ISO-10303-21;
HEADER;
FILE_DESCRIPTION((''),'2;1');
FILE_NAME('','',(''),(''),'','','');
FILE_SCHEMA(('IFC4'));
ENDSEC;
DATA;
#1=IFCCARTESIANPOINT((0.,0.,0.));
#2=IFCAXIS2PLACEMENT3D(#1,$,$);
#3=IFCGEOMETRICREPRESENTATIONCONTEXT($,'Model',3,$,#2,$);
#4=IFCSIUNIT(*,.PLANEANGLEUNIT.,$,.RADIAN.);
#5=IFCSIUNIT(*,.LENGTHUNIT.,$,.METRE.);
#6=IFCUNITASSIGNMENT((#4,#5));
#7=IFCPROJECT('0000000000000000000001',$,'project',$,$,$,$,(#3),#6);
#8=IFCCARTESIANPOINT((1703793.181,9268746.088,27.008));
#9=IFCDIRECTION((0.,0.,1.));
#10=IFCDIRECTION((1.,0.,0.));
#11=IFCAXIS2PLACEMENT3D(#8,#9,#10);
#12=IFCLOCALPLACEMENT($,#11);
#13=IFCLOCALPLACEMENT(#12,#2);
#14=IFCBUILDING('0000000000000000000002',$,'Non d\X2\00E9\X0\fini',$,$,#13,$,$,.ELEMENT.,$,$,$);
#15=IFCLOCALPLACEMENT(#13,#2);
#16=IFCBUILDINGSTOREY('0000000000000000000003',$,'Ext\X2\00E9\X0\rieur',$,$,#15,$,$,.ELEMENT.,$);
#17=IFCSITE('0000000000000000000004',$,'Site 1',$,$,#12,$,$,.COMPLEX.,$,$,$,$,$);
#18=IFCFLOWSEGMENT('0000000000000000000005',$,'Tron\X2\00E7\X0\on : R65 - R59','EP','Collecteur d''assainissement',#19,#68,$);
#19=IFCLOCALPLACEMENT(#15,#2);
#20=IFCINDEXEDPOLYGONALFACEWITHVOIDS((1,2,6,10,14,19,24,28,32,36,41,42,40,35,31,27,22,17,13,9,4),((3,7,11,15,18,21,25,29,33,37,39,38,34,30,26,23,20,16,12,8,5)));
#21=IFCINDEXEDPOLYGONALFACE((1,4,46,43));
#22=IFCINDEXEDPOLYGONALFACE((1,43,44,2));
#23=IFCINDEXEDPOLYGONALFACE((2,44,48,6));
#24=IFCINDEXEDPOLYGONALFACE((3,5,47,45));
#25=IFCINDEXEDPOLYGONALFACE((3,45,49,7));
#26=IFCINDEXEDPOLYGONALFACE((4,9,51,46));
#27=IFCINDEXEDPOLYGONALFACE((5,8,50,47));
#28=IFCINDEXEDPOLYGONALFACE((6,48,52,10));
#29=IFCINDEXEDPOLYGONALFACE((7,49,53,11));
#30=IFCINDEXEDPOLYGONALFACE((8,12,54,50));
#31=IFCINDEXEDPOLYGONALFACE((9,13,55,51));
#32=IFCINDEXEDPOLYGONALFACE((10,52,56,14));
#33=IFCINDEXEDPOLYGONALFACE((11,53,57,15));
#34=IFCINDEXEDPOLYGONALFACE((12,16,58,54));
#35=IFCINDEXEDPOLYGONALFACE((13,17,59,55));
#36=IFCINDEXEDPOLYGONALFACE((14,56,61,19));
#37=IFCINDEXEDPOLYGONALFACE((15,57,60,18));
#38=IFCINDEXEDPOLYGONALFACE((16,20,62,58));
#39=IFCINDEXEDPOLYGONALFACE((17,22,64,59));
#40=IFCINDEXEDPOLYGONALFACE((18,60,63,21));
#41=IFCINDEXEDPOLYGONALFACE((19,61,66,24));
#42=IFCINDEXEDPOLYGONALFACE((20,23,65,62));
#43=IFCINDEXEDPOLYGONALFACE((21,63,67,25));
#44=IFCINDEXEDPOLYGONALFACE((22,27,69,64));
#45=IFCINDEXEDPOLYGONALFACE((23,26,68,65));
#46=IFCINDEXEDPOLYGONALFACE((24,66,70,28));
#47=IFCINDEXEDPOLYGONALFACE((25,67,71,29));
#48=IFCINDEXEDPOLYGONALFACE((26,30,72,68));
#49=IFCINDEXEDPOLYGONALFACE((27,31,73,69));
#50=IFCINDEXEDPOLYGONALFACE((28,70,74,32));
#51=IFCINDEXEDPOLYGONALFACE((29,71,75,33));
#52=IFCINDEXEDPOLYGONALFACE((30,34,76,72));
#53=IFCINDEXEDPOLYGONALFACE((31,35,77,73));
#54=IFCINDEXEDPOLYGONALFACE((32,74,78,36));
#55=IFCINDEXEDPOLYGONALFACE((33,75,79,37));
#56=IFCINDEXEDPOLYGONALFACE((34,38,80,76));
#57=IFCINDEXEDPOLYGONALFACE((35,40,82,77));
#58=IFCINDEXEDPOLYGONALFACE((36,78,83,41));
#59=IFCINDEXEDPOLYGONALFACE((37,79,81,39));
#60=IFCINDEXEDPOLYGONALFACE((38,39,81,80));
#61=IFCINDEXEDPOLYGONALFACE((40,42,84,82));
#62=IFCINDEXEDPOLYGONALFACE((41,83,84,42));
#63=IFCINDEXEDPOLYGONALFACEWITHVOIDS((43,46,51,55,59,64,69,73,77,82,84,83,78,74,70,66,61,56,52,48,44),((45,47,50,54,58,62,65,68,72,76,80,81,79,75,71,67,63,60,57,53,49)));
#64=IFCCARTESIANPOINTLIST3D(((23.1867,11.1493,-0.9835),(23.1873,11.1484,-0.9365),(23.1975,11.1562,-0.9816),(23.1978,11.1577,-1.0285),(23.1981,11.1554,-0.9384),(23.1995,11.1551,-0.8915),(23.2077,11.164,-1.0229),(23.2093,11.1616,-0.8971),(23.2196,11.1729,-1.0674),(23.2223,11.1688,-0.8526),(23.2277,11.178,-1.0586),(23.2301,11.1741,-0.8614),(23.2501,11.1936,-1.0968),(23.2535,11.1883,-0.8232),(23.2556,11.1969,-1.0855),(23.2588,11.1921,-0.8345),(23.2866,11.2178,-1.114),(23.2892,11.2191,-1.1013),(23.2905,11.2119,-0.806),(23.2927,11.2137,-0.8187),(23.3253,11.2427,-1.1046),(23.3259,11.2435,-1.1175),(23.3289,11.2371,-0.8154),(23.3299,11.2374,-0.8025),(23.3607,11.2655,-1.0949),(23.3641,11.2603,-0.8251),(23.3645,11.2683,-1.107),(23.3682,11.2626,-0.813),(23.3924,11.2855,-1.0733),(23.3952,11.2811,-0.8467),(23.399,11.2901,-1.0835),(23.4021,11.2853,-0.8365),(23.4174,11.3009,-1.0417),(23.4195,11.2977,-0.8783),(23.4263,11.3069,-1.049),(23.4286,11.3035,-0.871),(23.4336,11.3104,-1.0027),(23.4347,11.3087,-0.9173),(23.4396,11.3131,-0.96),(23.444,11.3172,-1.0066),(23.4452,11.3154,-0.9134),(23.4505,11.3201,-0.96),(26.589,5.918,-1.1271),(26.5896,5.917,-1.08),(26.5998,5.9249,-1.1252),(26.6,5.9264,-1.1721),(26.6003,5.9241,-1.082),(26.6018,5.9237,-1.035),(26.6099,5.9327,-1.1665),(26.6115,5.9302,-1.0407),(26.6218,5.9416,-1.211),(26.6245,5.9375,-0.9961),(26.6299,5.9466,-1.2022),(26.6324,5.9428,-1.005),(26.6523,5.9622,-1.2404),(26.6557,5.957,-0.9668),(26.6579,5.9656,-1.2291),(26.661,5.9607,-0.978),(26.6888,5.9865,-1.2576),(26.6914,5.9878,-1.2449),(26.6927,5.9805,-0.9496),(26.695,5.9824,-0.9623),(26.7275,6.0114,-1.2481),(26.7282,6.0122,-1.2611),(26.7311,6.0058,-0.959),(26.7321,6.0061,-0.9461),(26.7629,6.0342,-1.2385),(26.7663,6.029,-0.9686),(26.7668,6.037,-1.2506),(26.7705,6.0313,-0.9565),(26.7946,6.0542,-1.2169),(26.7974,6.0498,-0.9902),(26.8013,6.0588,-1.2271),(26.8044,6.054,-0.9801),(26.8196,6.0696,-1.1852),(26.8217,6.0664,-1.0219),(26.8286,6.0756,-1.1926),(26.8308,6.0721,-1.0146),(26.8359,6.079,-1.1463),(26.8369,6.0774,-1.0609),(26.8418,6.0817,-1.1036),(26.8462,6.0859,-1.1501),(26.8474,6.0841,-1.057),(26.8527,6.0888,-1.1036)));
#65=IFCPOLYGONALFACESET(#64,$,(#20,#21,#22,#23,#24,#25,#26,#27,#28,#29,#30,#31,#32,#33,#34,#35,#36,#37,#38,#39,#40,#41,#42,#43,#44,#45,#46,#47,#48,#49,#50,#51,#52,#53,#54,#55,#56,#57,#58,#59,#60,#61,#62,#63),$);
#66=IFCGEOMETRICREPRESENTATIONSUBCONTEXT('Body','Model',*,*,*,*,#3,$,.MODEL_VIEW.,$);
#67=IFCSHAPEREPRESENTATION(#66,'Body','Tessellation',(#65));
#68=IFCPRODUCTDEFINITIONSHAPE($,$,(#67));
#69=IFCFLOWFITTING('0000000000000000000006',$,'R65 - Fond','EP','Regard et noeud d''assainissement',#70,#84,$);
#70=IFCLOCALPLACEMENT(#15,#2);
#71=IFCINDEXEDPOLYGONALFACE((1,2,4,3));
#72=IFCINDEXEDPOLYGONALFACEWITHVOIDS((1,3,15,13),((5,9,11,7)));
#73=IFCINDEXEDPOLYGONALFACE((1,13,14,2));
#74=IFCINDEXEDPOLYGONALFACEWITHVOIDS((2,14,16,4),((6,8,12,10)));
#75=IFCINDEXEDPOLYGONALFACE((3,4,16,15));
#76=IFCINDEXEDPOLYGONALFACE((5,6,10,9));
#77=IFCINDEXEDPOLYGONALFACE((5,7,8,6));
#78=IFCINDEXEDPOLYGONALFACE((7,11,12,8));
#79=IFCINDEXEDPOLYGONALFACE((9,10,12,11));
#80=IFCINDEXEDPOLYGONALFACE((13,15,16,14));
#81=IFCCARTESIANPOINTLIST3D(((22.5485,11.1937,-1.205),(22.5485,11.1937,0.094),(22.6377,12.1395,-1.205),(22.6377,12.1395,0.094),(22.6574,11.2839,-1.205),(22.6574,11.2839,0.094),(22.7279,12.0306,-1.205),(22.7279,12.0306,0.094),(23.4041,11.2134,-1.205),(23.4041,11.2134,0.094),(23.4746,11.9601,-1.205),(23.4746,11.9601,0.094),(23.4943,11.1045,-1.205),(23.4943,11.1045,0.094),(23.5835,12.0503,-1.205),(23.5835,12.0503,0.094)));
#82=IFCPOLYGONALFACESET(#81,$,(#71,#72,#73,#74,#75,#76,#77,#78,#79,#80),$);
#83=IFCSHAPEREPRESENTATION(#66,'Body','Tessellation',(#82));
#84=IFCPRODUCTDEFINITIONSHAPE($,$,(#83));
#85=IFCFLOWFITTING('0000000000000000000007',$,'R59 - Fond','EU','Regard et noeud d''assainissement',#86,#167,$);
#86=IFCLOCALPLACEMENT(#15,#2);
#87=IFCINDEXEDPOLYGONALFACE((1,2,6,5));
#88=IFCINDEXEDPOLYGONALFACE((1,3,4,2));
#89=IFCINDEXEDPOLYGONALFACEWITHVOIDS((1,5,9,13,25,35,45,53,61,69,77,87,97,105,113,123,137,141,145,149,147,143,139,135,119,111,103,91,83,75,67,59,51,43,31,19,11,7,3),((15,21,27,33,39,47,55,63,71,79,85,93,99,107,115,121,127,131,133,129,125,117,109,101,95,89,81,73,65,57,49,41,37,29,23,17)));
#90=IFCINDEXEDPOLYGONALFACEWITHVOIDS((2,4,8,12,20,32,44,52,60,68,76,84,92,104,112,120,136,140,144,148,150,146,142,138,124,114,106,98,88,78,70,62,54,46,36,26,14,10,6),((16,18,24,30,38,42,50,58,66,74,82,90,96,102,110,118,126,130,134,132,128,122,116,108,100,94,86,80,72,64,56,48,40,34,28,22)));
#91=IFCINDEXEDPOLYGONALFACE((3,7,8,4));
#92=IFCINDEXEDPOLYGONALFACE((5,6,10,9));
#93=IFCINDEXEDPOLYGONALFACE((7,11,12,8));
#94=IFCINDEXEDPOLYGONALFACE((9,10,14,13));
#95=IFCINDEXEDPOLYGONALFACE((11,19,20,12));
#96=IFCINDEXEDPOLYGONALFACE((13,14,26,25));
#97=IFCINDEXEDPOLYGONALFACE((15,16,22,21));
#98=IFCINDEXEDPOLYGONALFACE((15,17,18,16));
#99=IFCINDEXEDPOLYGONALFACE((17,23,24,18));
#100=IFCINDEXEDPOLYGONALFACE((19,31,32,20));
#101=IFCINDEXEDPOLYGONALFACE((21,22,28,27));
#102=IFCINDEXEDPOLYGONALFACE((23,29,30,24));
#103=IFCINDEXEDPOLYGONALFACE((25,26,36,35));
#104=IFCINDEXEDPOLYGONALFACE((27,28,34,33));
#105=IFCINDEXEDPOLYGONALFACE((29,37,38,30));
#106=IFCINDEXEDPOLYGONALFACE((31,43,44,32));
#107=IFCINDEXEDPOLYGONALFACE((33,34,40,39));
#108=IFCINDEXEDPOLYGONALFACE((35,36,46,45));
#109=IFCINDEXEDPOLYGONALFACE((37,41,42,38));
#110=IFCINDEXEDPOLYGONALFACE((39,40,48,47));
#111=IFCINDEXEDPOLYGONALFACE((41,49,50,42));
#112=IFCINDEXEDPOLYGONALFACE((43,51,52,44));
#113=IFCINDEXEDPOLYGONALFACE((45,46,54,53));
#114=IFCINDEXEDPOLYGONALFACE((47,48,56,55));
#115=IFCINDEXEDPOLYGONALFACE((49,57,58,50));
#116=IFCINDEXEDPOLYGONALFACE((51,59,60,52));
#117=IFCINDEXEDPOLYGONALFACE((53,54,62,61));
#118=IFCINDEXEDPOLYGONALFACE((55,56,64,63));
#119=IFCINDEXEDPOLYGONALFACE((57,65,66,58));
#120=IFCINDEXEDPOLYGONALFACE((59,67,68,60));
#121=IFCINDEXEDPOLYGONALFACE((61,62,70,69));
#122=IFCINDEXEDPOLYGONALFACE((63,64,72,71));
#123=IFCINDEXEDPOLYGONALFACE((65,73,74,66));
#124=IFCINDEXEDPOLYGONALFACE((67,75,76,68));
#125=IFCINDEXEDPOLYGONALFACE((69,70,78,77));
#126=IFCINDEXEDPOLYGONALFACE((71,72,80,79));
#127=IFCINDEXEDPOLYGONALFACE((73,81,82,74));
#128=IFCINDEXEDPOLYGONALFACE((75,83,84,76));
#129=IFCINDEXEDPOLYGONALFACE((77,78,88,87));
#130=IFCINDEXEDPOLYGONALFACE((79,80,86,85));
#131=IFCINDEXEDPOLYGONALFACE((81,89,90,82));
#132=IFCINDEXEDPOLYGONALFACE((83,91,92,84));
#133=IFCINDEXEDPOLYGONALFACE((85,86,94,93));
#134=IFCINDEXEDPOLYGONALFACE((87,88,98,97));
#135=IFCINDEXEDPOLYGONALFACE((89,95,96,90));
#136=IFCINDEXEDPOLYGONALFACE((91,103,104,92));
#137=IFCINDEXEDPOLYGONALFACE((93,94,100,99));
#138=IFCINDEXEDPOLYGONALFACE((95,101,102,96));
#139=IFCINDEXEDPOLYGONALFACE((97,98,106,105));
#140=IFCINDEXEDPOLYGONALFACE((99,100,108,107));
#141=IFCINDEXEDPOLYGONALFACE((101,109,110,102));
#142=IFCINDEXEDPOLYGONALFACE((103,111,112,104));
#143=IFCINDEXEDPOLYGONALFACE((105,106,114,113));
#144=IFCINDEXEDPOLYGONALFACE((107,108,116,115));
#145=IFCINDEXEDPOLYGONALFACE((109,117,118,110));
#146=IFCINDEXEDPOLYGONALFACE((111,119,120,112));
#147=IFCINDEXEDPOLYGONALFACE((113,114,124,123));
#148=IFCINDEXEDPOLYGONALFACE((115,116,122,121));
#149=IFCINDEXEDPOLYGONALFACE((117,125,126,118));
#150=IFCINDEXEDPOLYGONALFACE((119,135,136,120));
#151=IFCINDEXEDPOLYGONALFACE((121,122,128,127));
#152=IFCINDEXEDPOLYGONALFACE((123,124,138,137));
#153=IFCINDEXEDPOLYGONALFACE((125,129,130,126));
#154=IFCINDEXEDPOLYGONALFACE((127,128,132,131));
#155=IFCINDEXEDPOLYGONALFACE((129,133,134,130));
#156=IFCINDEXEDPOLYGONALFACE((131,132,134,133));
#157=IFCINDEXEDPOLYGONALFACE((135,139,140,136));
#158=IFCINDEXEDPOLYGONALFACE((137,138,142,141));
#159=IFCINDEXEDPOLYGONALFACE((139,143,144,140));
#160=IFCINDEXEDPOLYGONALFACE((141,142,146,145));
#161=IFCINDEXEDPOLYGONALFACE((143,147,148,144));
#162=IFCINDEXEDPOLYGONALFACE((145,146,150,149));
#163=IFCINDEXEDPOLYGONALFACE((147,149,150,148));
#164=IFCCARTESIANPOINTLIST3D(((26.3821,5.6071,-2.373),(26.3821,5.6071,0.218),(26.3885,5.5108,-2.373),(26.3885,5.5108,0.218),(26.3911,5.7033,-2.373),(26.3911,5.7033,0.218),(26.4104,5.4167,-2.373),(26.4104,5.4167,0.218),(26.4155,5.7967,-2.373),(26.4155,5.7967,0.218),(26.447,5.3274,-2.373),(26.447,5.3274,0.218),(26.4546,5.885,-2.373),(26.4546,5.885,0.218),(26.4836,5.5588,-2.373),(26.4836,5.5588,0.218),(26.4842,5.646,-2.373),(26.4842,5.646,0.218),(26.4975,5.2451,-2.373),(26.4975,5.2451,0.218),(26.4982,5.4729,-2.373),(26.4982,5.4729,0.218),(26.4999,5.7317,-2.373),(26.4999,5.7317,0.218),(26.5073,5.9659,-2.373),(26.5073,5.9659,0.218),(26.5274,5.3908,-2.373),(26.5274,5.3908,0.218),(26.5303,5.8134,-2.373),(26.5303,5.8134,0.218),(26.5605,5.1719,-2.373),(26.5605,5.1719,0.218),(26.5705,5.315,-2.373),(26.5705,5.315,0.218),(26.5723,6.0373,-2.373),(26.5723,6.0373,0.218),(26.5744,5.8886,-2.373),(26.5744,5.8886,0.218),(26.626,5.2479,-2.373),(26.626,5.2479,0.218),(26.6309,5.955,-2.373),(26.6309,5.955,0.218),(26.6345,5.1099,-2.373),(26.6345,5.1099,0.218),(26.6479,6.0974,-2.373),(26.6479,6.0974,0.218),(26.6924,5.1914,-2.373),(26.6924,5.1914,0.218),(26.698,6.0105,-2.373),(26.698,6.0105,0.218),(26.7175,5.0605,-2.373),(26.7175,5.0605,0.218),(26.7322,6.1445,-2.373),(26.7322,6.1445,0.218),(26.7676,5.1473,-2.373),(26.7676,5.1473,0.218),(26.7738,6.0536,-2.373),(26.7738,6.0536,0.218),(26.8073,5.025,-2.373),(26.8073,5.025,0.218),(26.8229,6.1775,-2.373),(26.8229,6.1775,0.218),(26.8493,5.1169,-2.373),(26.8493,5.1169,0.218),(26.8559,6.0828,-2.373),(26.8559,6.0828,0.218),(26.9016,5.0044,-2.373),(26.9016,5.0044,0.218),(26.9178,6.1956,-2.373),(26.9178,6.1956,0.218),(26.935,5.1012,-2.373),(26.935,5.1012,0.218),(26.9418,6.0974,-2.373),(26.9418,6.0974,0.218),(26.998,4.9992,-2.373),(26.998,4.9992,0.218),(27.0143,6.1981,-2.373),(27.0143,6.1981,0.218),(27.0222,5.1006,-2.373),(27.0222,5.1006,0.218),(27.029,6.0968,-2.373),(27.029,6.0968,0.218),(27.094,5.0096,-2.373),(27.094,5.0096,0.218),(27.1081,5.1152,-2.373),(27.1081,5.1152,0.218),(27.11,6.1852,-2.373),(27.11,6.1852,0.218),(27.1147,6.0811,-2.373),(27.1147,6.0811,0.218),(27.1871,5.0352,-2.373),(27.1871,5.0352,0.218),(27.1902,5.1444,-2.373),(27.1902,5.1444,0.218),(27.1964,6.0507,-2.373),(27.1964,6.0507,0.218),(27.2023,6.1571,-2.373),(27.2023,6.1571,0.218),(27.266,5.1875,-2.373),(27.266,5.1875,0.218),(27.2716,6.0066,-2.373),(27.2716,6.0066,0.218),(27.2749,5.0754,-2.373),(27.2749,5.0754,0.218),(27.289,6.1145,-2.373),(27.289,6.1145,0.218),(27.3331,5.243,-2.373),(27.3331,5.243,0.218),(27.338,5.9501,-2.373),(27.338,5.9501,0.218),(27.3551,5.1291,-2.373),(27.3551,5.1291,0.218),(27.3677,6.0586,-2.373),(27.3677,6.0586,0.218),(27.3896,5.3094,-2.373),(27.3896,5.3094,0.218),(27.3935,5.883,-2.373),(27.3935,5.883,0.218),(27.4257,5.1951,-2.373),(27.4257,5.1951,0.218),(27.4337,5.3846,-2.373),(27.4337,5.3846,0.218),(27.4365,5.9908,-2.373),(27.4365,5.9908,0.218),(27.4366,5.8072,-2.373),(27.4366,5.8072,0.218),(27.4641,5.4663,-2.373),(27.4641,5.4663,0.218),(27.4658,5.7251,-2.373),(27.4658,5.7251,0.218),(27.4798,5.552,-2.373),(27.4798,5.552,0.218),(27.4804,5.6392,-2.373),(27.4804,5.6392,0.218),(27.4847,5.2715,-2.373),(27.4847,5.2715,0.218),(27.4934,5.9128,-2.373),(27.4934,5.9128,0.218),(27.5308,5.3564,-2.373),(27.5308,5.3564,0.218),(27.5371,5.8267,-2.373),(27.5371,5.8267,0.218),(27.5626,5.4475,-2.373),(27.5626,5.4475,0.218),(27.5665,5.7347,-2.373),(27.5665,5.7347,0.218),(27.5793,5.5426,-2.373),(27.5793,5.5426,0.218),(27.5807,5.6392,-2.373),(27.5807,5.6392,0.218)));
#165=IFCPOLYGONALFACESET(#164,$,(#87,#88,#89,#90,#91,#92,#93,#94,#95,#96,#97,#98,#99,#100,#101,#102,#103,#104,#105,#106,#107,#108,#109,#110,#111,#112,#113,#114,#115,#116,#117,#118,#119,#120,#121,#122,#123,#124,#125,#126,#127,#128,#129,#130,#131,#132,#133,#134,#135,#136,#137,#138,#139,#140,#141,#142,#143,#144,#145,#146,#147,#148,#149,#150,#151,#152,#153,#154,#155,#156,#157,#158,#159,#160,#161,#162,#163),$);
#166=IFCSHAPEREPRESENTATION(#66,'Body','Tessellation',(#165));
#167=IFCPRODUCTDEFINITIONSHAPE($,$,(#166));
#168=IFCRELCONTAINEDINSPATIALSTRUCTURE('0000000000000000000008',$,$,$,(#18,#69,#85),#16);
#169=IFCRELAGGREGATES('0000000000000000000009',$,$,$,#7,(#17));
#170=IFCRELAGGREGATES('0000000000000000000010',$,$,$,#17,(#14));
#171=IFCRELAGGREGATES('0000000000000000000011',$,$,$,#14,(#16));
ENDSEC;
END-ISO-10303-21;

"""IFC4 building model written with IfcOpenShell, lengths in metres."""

from ifc_helpers import new_model, si_unit, frame, origin, origin_2d, place, context, subcontext, project, spatial, hollow_rectangle, hollow_circle, extrude, element, save


model = new_model("IFC4")

# Units and contexts
model_context = context("Model", 3, world=origin())
body_context = subcontext(model_context, "Body", "Model", "MODEL_VIEW")
ifc_project = project(units=[si_unit("PLANEANGLEUNIT", "RADIAN"), si_unit("LENGTHUNIT", "METRE")], contexts=[model_context])

# Site, building, storey
site_placement = place(None, frame((1703793.181, 9268746.088, 27.008), z_axis=(0.0, 0.0, 1.0), x_axis=(1.0, 0.0, 0.0)))
site = spatial("IfcSite", under=ifc_project, at=site_placement, Name="Site 1", CompositionType="COMPLEX")
building_placement = place(site_placement, origin())
building = spatial("IfcBuilding", under=site, at=building_placement, Name="Non défini", CompositionType="ELEMENT")
storey_placement = place(building_placement, origin())
storey = spatial("IfcBuildingStorey", under=building, at=storey_placement, Name="Extérieur", CompositionType="ELEMENT")

# Flow segment
flow_segment_1_placement = place(storey_placement, origin())
element("IfcFlowSegment", 1, at=flow_segment_1_placement, inside=storey, Name="Tronçon : R65 - R59", Description="EP", ObjectType="Collecteur d'assainissement", context=body_context, shape_type="SweptSolid", body=[
    extrude(hollow_circle(Radius=0.158, WallThickness=0.013, at=origin_2d()), frame((23.318, 11.234, -0.96), z_axis=(0.545, -0.838, -0.023), x_axis=(0.838, 0.545, 0.0)), (0.0, 0.0, 1.0), 6.242),
])

# Flow fittings
flow_fitting_1_placement = place(storey_placement, origin())
element("IfcFlowFitting", 2, at=flow_fitting_1_placement, inside=storey, Name="R65 - Fond", Description="EP", ObjectType="Regard et noeud d'assainissement", context=body_context, shape_type="SweptSolid", body=[
    extrude(hollow_rectangle(XDim=0.95, YDim=0.95, WallThickness=0.1, at=origin_2d()), frame((23.066, 11.622, -1.205), z_axis=(0.0, 0.0, 1.0), x_axis=(-0.094, -0.996, 0.0)), (0.0, 0.0, 1.0), 1.299),
])
flow_fitting_2_placement = place(storey_placement, origin())
element("IfcFlowFitting", 3, at=flow_fitting_2_placement, inside=storey, Name="R59 - Fond", Description="EU", ObjectType="Regard et noeud d'assainissement", context=body_context, shape_type="SweptSolid", body=[
    extrude(hollow_circle(Radius=0.6, WallThickness=0.1, at=origin_2d()), frame((26.982, 5.599, -2.373), z_axis=(0.0, 0.0, 1.0), x_axis=(0.996, -0.094, 0.0)), (0.0, 0.0, 1.0), 2.591),
])

save(model, "model.ifc")
